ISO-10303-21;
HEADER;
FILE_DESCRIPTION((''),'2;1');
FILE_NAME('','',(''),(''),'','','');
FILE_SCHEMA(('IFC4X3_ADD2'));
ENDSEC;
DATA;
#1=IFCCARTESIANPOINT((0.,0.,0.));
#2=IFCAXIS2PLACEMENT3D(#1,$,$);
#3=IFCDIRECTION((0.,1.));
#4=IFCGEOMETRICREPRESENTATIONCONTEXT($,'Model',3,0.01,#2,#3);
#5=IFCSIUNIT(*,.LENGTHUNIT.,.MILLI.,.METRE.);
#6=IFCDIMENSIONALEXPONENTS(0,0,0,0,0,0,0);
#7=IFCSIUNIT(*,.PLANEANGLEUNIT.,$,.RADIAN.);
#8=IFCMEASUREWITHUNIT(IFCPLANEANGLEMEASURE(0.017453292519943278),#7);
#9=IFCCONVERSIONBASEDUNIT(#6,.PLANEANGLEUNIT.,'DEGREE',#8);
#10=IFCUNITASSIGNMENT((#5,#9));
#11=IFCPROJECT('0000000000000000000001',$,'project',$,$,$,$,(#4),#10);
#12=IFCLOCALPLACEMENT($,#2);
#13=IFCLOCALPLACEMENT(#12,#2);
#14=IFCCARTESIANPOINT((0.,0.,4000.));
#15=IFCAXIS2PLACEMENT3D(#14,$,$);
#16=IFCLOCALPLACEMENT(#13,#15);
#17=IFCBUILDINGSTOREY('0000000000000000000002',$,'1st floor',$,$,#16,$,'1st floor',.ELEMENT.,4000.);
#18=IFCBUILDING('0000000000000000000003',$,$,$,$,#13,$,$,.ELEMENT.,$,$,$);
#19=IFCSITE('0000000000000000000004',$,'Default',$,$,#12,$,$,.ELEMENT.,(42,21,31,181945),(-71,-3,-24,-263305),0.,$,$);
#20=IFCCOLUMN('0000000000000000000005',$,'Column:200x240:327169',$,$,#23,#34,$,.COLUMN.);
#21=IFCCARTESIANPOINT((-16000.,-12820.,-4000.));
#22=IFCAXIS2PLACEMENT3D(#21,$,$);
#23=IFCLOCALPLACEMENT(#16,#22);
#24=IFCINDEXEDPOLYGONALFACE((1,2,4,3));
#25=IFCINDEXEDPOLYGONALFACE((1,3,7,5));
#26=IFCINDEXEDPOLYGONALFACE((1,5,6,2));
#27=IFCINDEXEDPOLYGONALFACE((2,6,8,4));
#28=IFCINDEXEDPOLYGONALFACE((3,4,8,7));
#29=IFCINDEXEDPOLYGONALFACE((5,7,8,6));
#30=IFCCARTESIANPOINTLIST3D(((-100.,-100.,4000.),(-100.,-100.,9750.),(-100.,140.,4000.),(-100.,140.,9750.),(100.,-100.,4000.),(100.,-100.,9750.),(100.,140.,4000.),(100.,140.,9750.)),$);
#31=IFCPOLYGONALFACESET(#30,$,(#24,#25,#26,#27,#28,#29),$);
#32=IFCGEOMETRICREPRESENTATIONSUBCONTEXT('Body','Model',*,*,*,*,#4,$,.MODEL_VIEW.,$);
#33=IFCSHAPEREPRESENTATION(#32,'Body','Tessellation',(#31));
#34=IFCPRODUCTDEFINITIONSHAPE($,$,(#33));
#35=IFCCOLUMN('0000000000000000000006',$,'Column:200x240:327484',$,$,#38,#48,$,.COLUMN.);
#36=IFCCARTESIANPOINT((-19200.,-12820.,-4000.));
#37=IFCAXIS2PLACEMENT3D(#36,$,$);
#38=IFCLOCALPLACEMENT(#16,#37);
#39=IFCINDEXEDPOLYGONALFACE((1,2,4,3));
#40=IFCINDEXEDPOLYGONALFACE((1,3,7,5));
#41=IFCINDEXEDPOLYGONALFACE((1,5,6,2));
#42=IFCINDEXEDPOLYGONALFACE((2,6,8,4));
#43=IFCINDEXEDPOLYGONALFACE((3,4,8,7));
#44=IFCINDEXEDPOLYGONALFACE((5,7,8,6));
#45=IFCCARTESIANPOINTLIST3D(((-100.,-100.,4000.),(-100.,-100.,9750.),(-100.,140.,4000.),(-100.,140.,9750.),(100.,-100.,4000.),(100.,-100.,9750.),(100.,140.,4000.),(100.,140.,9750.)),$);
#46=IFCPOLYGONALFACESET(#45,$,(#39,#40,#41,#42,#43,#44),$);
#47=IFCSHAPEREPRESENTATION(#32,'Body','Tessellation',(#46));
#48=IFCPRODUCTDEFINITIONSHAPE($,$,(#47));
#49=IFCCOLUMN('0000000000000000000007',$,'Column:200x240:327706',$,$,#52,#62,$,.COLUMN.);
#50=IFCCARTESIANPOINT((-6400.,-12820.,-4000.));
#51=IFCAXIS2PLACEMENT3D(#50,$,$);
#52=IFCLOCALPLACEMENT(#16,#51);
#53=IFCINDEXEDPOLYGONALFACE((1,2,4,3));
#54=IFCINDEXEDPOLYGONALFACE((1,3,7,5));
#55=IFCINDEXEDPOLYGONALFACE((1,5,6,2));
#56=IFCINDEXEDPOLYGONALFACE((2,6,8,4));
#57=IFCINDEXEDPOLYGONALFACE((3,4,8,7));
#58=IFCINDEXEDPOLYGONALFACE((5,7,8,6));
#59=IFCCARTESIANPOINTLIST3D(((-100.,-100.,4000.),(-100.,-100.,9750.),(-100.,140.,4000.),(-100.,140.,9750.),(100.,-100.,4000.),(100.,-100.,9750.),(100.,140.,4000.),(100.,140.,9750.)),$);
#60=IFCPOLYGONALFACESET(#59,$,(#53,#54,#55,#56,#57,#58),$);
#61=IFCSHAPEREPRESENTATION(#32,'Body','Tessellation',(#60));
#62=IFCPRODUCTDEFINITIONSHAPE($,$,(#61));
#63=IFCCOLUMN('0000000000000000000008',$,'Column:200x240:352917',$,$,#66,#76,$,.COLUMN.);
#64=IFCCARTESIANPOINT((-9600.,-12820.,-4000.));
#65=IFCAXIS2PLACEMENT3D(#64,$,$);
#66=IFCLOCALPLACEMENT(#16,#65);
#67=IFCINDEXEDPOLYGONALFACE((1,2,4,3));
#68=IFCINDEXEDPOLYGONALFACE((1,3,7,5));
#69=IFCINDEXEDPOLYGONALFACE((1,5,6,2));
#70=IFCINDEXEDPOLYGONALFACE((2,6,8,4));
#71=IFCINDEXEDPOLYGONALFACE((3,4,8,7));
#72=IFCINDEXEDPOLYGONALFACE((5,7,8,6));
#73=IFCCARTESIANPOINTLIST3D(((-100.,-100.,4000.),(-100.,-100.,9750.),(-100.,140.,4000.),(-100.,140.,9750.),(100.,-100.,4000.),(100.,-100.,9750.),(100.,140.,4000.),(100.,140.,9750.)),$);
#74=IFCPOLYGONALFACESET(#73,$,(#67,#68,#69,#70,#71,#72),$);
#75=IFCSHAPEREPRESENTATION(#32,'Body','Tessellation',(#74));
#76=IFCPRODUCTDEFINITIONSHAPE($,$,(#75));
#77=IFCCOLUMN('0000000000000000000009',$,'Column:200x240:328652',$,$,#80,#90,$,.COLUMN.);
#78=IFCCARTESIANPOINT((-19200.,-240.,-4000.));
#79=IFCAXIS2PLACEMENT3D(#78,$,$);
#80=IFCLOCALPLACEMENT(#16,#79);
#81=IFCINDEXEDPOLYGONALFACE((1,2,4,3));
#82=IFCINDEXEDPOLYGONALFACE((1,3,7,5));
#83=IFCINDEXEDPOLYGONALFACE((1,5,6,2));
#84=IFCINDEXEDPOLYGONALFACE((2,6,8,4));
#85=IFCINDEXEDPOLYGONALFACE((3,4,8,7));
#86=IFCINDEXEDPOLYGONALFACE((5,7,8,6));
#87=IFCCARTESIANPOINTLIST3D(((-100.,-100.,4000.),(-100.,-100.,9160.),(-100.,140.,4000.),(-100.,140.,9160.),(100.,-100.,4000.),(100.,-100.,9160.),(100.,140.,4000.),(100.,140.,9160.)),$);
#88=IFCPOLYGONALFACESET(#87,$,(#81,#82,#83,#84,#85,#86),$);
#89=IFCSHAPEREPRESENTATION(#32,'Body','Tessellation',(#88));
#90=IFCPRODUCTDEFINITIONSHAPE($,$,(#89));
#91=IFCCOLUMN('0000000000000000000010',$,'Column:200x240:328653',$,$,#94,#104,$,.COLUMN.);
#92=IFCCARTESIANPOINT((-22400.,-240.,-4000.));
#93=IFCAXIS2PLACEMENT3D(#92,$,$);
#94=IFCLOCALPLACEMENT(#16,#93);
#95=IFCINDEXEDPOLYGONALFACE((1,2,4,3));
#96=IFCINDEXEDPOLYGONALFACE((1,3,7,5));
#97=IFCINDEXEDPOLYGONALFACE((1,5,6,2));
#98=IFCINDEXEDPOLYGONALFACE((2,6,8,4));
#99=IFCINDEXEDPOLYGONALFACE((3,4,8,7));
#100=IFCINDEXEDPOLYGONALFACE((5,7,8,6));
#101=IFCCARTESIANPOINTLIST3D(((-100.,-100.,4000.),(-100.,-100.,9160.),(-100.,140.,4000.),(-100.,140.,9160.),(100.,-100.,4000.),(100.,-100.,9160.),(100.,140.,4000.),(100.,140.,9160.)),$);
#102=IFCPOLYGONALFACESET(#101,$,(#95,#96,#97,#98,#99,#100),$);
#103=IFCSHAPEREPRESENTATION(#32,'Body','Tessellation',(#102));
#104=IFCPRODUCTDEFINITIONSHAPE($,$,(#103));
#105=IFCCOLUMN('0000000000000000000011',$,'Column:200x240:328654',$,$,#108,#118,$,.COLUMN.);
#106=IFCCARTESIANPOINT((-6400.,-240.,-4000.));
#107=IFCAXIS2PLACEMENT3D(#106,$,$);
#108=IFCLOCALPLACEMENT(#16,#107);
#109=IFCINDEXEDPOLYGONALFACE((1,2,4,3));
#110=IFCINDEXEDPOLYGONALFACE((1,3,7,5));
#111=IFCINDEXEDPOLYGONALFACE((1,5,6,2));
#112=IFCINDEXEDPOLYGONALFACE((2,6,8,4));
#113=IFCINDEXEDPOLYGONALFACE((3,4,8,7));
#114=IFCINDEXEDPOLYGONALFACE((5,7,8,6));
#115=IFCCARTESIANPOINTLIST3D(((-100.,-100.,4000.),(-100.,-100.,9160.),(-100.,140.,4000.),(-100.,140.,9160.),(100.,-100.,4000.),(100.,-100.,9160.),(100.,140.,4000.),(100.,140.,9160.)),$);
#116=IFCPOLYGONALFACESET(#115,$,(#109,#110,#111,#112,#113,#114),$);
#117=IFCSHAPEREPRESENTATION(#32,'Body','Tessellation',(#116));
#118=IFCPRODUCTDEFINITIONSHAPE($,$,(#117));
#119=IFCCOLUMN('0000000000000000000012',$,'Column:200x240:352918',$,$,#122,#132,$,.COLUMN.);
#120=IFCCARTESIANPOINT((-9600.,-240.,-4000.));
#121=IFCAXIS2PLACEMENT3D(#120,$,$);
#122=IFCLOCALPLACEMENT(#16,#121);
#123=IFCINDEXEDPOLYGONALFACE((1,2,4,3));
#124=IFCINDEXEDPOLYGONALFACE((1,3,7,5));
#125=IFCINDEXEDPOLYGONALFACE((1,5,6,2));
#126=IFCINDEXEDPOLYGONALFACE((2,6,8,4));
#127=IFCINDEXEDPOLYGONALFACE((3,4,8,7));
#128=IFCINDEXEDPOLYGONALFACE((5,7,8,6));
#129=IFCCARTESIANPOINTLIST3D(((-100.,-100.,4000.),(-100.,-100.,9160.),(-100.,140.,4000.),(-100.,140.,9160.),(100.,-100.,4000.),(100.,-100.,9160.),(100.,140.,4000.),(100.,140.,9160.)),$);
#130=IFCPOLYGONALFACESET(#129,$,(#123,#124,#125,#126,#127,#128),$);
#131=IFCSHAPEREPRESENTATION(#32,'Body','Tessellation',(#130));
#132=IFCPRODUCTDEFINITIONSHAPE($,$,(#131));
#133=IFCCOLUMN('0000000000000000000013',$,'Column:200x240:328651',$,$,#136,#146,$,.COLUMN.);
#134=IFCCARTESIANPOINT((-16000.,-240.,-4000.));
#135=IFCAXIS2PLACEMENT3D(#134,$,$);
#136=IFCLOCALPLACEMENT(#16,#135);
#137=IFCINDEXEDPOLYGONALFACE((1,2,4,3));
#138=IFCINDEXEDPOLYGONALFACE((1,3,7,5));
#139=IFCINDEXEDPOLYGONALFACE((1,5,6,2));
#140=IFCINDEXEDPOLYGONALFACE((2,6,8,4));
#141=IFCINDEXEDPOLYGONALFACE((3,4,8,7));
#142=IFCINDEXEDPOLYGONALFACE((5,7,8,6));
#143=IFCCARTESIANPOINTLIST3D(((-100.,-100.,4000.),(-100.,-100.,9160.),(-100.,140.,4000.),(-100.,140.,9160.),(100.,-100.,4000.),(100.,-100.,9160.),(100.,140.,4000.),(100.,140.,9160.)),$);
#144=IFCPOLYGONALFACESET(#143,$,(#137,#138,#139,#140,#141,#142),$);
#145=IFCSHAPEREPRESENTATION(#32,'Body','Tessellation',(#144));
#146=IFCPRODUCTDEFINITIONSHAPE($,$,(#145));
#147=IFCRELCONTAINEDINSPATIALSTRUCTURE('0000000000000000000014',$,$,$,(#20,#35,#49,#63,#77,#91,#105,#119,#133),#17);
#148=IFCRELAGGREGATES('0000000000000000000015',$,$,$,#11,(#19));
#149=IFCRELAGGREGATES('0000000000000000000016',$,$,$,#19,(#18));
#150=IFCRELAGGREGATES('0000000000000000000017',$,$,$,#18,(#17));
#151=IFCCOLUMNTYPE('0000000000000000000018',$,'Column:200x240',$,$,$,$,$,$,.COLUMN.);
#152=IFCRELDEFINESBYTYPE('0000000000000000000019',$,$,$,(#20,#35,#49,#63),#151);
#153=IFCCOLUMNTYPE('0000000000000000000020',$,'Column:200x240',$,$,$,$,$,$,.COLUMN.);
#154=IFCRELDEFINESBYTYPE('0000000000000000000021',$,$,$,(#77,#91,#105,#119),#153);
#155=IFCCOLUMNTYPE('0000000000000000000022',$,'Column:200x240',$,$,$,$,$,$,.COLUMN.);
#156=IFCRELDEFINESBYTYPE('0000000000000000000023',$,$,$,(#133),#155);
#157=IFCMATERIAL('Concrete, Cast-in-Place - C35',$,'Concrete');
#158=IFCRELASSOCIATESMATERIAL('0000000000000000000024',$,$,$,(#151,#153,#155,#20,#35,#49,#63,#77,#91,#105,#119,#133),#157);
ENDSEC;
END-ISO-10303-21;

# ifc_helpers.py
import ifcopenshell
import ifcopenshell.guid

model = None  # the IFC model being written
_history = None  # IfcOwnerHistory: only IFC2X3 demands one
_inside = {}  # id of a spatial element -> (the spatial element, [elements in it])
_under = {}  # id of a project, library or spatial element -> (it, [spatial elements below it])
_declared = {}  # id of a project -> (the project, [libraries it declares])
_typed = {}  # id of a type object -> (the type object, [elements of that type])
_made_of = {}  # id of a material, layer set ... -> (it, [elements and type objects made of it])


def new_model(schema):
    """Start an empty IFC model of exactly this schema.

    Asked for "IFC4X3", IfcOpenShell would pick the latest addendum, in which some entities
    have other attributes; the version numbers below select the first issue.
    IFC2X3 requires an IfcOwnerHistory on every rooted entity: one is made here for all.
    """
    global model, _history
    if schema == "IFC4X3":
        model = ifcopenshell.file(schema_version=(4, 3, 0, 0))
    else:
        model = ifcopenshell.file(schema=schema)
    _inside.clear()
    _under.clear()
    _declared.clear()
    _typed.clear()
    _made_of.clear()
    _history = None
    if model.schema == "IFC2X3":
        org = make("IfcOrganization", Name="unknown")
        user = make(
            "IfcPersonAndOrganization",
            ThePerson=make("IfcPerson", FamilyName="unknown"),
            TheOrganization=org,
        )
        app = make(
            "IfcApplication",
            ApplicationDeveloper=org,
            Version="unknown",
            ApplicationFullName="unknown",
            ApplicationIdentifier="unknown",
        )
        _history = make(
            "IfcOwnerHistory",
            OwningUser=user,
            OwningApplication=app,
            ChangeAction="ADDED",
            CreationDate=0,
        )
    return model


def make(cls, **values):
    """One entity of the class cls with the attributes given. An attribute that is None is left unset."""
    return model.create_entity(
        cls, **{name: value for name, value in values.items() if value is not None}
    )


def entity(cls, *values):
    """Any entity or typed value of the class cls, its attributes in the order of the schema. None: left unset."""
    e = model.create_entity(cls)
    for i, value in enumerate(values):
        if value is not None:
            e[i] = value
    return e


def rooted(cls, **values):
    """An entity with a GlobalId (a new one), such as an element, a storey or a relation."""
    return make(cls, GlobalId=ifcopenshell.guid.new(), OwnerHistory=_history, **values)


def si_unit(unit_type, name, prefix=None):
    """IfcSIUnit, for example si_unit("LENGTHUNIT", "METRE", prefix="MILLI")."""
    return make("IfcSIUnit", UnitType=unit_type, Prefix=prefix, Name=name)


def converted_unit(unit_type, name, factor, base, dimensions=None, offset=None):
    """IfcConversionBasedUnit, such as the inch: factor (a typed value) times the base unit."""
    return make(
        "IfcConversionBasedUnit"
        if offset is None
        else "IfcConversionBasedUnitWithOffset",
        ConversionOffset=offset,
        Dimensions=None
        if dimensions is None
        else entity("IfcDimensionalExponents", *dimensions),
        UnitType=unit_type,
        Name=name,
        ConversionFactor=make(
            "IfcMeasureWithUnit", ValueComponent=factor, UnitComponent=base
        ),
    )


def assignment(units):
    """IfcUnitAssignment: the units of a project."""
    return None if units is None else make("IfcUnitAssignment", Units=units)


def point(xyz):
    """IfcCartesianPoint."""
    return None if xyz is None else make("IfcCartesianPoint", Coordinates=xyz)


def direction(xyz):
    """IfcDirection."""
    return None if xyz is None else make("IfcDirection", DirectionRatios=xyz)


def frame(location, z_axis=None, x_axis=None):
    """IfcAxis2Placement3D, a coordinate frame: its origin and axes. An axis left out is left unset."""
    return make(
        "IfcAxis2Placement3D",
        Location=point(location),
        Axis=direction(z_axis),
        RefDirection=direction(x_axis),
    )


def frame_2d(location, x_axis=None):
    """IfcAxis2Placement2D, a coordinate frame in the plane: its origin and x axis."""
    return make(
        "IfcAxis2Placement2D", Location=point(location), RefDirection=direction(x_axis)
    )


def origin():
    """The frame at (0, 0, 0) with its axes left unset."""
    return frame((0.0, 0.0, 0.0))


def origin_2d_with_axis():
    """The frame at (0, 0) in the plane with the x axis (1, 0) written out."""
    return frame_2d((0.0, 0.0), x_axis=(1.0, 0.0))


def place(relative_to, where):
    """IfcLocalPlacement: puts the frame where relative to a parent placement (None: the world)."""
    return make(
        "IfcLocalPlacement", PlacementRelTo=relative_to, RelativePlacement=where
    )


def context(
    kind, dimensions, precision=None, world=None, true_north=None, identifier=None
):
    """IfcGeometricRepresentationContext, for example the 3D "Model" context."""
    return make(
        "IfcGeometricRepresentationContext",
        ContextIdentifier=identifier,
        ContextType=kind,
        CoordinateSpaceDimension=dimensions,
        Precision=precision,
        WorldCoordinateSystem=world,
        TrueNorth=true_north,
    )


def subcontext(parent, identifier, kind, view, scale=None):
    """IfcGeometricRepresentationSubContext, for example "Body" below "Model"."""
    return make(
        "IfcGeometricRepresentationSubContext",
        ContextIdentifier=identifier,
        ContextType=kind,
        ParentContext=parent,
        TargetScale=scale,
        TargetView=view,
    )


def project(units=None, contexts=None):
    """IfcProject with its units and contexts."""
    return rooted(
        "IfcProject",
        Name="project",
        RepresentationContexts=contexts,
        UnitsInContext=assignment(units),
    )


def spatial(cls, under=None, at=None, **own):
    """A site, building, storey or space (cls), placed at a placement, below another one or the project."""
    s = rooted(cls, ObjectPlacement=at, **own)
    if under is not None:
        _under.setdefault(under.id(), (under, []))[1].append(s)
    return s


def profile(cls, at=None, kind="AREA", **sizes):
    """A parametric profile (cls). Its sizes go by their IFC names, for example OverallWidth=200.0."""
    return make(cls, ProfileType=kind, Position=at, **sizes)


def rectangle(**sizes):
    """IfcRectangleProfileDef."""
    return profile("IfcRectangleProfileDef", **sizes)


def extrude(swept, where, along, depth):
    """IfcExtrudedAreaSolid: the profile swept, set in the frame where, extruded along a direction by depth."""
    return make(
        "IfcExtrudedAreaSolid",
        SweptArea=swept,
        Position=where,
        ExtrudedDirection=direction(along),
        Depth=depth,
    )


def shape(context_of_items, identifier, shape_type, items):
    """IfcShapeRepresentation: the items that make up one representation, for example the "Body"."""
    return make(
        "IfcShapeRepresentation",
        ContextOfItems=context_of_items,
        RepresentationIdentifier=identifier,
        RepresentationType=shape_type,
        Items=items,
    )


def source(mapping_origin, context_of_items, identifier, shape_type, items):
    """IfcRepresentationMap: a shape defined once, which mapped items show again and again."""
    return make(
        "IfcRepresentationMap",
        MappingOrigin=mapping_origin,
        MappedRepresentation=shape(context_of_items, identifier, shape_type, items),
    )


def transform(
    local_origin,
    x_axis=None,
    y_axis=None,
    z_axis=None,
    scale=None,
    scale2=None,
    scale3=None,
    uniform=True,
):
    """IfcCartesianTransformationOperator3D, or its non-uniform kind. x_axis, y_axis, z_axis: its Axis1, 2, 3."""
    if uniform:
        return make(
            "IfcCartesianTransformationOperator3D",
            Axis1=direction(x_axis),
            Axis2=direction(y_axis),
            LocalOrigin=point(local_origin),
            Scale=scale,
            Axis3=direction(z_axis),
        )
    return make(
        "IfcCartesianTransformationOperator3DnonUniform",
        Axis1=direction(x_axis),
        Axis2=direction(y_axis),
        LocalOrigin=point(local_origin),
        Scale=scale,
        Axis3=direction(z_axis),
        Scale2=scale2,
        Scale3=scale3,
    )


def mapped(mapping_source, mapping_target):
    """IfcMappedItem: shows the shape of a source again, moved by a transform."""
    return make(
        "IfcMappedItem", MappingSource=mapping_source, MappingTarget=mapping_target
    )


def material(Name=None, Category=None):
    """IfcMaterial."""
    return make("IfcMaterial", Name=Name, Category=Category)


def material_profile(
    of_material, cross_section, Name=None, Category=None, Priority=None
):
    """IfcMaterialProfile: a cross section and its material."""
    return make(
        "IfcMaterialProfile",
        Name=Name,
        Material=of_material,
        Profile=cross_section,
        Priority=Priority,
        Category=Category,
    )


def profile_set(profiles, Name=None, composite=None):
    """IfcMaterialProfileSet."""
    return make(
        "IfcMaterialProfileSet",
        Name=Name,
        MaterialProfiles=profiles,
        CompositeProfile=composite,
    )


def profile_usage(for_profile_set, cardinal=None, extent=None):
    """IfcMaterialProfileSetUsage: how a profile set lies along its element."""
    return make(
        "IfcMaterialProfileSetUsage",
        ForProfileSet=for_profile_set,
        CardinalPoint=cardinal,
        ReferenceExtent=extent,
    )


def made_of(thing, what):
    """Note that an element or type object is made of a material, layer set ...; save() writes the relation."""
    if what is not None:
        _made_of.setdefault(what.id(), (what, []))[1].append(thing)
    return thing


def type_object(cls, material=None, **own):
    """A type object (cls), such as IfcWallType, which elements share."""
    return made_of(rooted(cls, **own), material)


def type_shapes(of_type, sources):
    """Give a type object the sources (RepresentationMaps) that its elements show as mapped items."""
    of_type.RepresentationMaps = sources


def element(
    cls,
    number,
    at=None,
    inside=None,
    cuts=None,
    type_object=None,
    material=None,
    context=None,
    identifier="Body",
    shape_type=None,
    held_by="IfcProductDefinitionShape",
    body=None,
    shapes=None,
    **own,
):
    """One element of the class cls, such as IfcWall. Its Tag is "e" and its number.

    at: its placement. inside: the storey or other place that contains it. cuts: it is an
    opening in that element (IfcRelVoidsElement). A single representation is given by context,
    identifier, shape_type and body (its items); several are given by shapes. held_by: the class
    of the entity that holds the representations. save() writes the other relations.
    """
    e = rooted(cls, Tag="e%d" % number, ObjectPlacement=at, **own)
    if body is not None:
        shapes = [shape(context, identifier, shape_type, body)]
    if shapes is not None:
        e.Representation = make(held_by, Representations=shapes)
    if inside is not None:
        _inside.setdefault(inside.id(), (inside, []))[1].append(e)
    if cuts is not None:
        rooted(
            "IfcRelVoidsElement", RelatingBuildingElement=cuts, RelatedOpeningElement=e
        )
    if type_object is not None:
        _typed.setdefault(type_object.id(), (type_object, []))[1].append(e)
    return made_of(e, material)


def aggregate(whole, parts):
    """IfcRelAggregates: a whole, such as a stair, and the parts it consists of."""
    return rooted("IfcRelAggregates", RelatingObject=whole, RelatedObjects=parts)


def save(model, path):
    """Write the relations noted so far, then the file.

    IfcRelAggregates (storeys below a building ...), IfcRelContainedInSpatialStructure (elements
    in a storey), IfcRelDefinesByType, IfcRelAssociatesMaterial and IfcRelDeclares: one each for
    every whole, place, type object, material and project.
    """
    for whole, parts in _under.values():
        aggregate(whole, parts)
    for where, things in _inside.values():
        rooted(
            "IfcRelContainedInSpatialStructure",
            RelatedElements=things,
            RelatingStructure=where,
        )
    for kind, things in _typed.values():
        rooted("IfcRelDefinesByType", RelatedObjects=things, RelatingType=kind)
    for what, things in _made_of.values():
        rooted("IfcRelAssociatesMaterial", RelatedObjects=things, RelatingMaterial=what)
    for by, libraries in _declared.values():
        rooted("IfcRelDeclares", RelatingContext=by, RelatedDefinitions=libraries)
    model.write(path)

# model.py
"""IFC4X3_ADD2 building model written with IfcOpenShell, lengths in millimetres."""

from ifc_helpers import new_model, entity, si_unit, converted_unit, direction, frame, origin, origin_2d_with_axis, place, context, subcontext, project, spatial, rectangle, extrude, source, transform, mapped, material, material_profile, profile_set, profile_usage, type_object, type_shapes, element, save


model = new_model("IFC4X3_ADD2")

# Units and contexts
model_context = context("Model", 3, precision=0.01, world=origin(), true_north=direction((0.0, 1.0)))
body_context = subcontext(model_context, "Body", "Model", "MODEL_VIEW")
ifc_project = project(units=[si_unit("LENGTHUNIT", "METRE", prefix="MILLI"), converted_unit("PLANEANGLEUNIT", "DEGREE", entity("IfcPlaneAngleMeasure", 0.017453292519943278), si_unit("PLANEANGLEUNIT", "RADIAN"), dimensions=[0, 0, 0, 0, 0, 0, 0])], contexts=[model_context])

# Site, building, storey
site_placement = place(None, origin())
site = spatial("IfcSite", under=ifc_project, at=site_placement, Name="Default", CompositionType="ELEMENT", RefLatitude=(42, 21, 31, 181945), RefLongitude=(-71, -3, -24, -263305), RefElevation=0.0)
building_placement = place(site_placement, origin())
building = spatial("IfcBuilding", under=site, at=building_placement, CompositionType="ELEMENT")
storey_placement = place(building_placement, frame((0.0, 0.0, 4000.0)))
storey = spatial("IfcBuildingStorey", under=building, at=storey_placement, Name="1st floor", LongName="1st floor", CompositionType="ELEMENT", Elevation=4000.0)

# Columns
ifc_material = material(Name="Concrete, Cast-in-Place - C35", Category="Concrete")
ifc_material_profile_1 = material_profile(ifc_material, rectangle(XDim=200.0, YDim=240.0, at=origin_2d_with_axis()), Name="200x240")
ifc_profile_set_1 = profile_set([ifc_material_profile_1], Name="200x240")
ifc_profile_usage_1 = profile_usage(ifc_profile_set_1)
column_type_1 = type_object("IfcColumnType", Name="Column:200x240", PredefinedType="COLUMN", material=ifc_profile_set_1)
shared_shape_1 = source(origin(), body_context, "Body", "SweptSolid", [
    extrude(rectangle(XDim=200.0, YDim=240.0, at=origin_2d_with_axis()), frame((0.0, 20.0, 4000.0), z_axis=(0.0, 0.0, 1.0), x_axis=(-1.0, 0.0, 0.0)), (0.0, 0.0, 1.0), 5750.0),
])
type_shapes(column_type_1, [shared_shape_1])
for number, where, name in (
    (1, (-16000.0, -12820.0, -4000.0), "Column:200x240:327169"),
    (2, (-19200.0, -12820.0, -4000.0), "Column:200x240:327484"),
    (3, (-6400.0, -12820.0, -4000.0), "Column:200x240:327706"),
    (4, (-9600.0, -12820.0, -4000.0), "Column:200x240:352917"),
):
    element("IfcColumn", number, at=place(storey_placement, frame(where)), inside=storey, type_object=column_type_1, material=ifc_profile_usage_1, Name=name, PredefinedType="COLUMN", context=body_context, shape_type="MappedRepresentation", body=[
        mapped(shared_shape_1, transform((0.0, 0.0, 0.0), scale=1.0)),
    ])
column_type_2 = type_object("IfcColumnType", Name="Column:200x240", PredefinedType="COLUMN", material=ifc_profile_set_1)
shared_shape_2 = source(origin(), body_context, "Body", "SweptSolid", [
    extrude(rectangle(XDim=200.0, YDim=240.0, at=origin_2d_with_axis()), frame((0.0, 20.0, 4000.0), z_axis=(0.0, 0.0, 1.0), x_axis=(-1.0, 0.0, 0.0)), (0.0, 0.0, 1.0), 5160.0),
])
type_shapes(column_type_2, [shared_shape_2])
for number, where, name in (
    (5, (-19200.0, -240.0, -4000.0), "Column:200x240:328652"),
    (6, (-22400.0, -240.0, -4000.0), "Column:200x240:328653"),
    (7, (-6400.0, -240.0, -4000.0), "Column:200x240:328654"),
    (8, (-9600.0, -240.0, -4000.0), "Column:200x240:352918"),
):
    element("IfcColumn", number, at=place(storey_placement, frame(where)), inside=storey, type_object=column_type_2, material=ifc_profile_usage_1, Name=name, PredefinedType="COLUMN", context=body_context, shape_type="MappedRepresentation", body=[
        mapped(shared_shape_2, transform((0.0, 0.0, 0.0), scale=1.0)),
    ])
column_type_3 = type_object("IfcColumnType", Name="Column:200x240", PredefinedType="COLUMN", material=ifc_profile_set_1)
shared_shape_3 = source(origin(), body_context, "Body", "SweptSolid", [
    extrude(rectangle(XDim=200.0, YDim=240.0, at=origin_2d_with_axis()), frame((0.0, 20.0, 4000.0), z_axis=(0.0, 0.0, 1.0), x_axis=(-1.0, 0.0, 0.0)), (0.0, 0.0, 1.0), 5160.0),
])
type_shapes(column_type_3, [shared_shape_3])
column_placement = place(storey_placement, frame((-16000.0, -240.0, -4000.0)))
element("IfcColumn", 9, at=column_placement, inside=storey, type_object=column_type_3, material=ifc_profile_usage_1, Name="Column:200x240:328651", PredefinedType="COLUMN", context=body_context, shape_type="MappedRepresentation", body=[
    mapped(shared_shape_3, transform((0.0, 0.0, 0.0), scale=1.0)),
])

save(model, "model.ifc")
